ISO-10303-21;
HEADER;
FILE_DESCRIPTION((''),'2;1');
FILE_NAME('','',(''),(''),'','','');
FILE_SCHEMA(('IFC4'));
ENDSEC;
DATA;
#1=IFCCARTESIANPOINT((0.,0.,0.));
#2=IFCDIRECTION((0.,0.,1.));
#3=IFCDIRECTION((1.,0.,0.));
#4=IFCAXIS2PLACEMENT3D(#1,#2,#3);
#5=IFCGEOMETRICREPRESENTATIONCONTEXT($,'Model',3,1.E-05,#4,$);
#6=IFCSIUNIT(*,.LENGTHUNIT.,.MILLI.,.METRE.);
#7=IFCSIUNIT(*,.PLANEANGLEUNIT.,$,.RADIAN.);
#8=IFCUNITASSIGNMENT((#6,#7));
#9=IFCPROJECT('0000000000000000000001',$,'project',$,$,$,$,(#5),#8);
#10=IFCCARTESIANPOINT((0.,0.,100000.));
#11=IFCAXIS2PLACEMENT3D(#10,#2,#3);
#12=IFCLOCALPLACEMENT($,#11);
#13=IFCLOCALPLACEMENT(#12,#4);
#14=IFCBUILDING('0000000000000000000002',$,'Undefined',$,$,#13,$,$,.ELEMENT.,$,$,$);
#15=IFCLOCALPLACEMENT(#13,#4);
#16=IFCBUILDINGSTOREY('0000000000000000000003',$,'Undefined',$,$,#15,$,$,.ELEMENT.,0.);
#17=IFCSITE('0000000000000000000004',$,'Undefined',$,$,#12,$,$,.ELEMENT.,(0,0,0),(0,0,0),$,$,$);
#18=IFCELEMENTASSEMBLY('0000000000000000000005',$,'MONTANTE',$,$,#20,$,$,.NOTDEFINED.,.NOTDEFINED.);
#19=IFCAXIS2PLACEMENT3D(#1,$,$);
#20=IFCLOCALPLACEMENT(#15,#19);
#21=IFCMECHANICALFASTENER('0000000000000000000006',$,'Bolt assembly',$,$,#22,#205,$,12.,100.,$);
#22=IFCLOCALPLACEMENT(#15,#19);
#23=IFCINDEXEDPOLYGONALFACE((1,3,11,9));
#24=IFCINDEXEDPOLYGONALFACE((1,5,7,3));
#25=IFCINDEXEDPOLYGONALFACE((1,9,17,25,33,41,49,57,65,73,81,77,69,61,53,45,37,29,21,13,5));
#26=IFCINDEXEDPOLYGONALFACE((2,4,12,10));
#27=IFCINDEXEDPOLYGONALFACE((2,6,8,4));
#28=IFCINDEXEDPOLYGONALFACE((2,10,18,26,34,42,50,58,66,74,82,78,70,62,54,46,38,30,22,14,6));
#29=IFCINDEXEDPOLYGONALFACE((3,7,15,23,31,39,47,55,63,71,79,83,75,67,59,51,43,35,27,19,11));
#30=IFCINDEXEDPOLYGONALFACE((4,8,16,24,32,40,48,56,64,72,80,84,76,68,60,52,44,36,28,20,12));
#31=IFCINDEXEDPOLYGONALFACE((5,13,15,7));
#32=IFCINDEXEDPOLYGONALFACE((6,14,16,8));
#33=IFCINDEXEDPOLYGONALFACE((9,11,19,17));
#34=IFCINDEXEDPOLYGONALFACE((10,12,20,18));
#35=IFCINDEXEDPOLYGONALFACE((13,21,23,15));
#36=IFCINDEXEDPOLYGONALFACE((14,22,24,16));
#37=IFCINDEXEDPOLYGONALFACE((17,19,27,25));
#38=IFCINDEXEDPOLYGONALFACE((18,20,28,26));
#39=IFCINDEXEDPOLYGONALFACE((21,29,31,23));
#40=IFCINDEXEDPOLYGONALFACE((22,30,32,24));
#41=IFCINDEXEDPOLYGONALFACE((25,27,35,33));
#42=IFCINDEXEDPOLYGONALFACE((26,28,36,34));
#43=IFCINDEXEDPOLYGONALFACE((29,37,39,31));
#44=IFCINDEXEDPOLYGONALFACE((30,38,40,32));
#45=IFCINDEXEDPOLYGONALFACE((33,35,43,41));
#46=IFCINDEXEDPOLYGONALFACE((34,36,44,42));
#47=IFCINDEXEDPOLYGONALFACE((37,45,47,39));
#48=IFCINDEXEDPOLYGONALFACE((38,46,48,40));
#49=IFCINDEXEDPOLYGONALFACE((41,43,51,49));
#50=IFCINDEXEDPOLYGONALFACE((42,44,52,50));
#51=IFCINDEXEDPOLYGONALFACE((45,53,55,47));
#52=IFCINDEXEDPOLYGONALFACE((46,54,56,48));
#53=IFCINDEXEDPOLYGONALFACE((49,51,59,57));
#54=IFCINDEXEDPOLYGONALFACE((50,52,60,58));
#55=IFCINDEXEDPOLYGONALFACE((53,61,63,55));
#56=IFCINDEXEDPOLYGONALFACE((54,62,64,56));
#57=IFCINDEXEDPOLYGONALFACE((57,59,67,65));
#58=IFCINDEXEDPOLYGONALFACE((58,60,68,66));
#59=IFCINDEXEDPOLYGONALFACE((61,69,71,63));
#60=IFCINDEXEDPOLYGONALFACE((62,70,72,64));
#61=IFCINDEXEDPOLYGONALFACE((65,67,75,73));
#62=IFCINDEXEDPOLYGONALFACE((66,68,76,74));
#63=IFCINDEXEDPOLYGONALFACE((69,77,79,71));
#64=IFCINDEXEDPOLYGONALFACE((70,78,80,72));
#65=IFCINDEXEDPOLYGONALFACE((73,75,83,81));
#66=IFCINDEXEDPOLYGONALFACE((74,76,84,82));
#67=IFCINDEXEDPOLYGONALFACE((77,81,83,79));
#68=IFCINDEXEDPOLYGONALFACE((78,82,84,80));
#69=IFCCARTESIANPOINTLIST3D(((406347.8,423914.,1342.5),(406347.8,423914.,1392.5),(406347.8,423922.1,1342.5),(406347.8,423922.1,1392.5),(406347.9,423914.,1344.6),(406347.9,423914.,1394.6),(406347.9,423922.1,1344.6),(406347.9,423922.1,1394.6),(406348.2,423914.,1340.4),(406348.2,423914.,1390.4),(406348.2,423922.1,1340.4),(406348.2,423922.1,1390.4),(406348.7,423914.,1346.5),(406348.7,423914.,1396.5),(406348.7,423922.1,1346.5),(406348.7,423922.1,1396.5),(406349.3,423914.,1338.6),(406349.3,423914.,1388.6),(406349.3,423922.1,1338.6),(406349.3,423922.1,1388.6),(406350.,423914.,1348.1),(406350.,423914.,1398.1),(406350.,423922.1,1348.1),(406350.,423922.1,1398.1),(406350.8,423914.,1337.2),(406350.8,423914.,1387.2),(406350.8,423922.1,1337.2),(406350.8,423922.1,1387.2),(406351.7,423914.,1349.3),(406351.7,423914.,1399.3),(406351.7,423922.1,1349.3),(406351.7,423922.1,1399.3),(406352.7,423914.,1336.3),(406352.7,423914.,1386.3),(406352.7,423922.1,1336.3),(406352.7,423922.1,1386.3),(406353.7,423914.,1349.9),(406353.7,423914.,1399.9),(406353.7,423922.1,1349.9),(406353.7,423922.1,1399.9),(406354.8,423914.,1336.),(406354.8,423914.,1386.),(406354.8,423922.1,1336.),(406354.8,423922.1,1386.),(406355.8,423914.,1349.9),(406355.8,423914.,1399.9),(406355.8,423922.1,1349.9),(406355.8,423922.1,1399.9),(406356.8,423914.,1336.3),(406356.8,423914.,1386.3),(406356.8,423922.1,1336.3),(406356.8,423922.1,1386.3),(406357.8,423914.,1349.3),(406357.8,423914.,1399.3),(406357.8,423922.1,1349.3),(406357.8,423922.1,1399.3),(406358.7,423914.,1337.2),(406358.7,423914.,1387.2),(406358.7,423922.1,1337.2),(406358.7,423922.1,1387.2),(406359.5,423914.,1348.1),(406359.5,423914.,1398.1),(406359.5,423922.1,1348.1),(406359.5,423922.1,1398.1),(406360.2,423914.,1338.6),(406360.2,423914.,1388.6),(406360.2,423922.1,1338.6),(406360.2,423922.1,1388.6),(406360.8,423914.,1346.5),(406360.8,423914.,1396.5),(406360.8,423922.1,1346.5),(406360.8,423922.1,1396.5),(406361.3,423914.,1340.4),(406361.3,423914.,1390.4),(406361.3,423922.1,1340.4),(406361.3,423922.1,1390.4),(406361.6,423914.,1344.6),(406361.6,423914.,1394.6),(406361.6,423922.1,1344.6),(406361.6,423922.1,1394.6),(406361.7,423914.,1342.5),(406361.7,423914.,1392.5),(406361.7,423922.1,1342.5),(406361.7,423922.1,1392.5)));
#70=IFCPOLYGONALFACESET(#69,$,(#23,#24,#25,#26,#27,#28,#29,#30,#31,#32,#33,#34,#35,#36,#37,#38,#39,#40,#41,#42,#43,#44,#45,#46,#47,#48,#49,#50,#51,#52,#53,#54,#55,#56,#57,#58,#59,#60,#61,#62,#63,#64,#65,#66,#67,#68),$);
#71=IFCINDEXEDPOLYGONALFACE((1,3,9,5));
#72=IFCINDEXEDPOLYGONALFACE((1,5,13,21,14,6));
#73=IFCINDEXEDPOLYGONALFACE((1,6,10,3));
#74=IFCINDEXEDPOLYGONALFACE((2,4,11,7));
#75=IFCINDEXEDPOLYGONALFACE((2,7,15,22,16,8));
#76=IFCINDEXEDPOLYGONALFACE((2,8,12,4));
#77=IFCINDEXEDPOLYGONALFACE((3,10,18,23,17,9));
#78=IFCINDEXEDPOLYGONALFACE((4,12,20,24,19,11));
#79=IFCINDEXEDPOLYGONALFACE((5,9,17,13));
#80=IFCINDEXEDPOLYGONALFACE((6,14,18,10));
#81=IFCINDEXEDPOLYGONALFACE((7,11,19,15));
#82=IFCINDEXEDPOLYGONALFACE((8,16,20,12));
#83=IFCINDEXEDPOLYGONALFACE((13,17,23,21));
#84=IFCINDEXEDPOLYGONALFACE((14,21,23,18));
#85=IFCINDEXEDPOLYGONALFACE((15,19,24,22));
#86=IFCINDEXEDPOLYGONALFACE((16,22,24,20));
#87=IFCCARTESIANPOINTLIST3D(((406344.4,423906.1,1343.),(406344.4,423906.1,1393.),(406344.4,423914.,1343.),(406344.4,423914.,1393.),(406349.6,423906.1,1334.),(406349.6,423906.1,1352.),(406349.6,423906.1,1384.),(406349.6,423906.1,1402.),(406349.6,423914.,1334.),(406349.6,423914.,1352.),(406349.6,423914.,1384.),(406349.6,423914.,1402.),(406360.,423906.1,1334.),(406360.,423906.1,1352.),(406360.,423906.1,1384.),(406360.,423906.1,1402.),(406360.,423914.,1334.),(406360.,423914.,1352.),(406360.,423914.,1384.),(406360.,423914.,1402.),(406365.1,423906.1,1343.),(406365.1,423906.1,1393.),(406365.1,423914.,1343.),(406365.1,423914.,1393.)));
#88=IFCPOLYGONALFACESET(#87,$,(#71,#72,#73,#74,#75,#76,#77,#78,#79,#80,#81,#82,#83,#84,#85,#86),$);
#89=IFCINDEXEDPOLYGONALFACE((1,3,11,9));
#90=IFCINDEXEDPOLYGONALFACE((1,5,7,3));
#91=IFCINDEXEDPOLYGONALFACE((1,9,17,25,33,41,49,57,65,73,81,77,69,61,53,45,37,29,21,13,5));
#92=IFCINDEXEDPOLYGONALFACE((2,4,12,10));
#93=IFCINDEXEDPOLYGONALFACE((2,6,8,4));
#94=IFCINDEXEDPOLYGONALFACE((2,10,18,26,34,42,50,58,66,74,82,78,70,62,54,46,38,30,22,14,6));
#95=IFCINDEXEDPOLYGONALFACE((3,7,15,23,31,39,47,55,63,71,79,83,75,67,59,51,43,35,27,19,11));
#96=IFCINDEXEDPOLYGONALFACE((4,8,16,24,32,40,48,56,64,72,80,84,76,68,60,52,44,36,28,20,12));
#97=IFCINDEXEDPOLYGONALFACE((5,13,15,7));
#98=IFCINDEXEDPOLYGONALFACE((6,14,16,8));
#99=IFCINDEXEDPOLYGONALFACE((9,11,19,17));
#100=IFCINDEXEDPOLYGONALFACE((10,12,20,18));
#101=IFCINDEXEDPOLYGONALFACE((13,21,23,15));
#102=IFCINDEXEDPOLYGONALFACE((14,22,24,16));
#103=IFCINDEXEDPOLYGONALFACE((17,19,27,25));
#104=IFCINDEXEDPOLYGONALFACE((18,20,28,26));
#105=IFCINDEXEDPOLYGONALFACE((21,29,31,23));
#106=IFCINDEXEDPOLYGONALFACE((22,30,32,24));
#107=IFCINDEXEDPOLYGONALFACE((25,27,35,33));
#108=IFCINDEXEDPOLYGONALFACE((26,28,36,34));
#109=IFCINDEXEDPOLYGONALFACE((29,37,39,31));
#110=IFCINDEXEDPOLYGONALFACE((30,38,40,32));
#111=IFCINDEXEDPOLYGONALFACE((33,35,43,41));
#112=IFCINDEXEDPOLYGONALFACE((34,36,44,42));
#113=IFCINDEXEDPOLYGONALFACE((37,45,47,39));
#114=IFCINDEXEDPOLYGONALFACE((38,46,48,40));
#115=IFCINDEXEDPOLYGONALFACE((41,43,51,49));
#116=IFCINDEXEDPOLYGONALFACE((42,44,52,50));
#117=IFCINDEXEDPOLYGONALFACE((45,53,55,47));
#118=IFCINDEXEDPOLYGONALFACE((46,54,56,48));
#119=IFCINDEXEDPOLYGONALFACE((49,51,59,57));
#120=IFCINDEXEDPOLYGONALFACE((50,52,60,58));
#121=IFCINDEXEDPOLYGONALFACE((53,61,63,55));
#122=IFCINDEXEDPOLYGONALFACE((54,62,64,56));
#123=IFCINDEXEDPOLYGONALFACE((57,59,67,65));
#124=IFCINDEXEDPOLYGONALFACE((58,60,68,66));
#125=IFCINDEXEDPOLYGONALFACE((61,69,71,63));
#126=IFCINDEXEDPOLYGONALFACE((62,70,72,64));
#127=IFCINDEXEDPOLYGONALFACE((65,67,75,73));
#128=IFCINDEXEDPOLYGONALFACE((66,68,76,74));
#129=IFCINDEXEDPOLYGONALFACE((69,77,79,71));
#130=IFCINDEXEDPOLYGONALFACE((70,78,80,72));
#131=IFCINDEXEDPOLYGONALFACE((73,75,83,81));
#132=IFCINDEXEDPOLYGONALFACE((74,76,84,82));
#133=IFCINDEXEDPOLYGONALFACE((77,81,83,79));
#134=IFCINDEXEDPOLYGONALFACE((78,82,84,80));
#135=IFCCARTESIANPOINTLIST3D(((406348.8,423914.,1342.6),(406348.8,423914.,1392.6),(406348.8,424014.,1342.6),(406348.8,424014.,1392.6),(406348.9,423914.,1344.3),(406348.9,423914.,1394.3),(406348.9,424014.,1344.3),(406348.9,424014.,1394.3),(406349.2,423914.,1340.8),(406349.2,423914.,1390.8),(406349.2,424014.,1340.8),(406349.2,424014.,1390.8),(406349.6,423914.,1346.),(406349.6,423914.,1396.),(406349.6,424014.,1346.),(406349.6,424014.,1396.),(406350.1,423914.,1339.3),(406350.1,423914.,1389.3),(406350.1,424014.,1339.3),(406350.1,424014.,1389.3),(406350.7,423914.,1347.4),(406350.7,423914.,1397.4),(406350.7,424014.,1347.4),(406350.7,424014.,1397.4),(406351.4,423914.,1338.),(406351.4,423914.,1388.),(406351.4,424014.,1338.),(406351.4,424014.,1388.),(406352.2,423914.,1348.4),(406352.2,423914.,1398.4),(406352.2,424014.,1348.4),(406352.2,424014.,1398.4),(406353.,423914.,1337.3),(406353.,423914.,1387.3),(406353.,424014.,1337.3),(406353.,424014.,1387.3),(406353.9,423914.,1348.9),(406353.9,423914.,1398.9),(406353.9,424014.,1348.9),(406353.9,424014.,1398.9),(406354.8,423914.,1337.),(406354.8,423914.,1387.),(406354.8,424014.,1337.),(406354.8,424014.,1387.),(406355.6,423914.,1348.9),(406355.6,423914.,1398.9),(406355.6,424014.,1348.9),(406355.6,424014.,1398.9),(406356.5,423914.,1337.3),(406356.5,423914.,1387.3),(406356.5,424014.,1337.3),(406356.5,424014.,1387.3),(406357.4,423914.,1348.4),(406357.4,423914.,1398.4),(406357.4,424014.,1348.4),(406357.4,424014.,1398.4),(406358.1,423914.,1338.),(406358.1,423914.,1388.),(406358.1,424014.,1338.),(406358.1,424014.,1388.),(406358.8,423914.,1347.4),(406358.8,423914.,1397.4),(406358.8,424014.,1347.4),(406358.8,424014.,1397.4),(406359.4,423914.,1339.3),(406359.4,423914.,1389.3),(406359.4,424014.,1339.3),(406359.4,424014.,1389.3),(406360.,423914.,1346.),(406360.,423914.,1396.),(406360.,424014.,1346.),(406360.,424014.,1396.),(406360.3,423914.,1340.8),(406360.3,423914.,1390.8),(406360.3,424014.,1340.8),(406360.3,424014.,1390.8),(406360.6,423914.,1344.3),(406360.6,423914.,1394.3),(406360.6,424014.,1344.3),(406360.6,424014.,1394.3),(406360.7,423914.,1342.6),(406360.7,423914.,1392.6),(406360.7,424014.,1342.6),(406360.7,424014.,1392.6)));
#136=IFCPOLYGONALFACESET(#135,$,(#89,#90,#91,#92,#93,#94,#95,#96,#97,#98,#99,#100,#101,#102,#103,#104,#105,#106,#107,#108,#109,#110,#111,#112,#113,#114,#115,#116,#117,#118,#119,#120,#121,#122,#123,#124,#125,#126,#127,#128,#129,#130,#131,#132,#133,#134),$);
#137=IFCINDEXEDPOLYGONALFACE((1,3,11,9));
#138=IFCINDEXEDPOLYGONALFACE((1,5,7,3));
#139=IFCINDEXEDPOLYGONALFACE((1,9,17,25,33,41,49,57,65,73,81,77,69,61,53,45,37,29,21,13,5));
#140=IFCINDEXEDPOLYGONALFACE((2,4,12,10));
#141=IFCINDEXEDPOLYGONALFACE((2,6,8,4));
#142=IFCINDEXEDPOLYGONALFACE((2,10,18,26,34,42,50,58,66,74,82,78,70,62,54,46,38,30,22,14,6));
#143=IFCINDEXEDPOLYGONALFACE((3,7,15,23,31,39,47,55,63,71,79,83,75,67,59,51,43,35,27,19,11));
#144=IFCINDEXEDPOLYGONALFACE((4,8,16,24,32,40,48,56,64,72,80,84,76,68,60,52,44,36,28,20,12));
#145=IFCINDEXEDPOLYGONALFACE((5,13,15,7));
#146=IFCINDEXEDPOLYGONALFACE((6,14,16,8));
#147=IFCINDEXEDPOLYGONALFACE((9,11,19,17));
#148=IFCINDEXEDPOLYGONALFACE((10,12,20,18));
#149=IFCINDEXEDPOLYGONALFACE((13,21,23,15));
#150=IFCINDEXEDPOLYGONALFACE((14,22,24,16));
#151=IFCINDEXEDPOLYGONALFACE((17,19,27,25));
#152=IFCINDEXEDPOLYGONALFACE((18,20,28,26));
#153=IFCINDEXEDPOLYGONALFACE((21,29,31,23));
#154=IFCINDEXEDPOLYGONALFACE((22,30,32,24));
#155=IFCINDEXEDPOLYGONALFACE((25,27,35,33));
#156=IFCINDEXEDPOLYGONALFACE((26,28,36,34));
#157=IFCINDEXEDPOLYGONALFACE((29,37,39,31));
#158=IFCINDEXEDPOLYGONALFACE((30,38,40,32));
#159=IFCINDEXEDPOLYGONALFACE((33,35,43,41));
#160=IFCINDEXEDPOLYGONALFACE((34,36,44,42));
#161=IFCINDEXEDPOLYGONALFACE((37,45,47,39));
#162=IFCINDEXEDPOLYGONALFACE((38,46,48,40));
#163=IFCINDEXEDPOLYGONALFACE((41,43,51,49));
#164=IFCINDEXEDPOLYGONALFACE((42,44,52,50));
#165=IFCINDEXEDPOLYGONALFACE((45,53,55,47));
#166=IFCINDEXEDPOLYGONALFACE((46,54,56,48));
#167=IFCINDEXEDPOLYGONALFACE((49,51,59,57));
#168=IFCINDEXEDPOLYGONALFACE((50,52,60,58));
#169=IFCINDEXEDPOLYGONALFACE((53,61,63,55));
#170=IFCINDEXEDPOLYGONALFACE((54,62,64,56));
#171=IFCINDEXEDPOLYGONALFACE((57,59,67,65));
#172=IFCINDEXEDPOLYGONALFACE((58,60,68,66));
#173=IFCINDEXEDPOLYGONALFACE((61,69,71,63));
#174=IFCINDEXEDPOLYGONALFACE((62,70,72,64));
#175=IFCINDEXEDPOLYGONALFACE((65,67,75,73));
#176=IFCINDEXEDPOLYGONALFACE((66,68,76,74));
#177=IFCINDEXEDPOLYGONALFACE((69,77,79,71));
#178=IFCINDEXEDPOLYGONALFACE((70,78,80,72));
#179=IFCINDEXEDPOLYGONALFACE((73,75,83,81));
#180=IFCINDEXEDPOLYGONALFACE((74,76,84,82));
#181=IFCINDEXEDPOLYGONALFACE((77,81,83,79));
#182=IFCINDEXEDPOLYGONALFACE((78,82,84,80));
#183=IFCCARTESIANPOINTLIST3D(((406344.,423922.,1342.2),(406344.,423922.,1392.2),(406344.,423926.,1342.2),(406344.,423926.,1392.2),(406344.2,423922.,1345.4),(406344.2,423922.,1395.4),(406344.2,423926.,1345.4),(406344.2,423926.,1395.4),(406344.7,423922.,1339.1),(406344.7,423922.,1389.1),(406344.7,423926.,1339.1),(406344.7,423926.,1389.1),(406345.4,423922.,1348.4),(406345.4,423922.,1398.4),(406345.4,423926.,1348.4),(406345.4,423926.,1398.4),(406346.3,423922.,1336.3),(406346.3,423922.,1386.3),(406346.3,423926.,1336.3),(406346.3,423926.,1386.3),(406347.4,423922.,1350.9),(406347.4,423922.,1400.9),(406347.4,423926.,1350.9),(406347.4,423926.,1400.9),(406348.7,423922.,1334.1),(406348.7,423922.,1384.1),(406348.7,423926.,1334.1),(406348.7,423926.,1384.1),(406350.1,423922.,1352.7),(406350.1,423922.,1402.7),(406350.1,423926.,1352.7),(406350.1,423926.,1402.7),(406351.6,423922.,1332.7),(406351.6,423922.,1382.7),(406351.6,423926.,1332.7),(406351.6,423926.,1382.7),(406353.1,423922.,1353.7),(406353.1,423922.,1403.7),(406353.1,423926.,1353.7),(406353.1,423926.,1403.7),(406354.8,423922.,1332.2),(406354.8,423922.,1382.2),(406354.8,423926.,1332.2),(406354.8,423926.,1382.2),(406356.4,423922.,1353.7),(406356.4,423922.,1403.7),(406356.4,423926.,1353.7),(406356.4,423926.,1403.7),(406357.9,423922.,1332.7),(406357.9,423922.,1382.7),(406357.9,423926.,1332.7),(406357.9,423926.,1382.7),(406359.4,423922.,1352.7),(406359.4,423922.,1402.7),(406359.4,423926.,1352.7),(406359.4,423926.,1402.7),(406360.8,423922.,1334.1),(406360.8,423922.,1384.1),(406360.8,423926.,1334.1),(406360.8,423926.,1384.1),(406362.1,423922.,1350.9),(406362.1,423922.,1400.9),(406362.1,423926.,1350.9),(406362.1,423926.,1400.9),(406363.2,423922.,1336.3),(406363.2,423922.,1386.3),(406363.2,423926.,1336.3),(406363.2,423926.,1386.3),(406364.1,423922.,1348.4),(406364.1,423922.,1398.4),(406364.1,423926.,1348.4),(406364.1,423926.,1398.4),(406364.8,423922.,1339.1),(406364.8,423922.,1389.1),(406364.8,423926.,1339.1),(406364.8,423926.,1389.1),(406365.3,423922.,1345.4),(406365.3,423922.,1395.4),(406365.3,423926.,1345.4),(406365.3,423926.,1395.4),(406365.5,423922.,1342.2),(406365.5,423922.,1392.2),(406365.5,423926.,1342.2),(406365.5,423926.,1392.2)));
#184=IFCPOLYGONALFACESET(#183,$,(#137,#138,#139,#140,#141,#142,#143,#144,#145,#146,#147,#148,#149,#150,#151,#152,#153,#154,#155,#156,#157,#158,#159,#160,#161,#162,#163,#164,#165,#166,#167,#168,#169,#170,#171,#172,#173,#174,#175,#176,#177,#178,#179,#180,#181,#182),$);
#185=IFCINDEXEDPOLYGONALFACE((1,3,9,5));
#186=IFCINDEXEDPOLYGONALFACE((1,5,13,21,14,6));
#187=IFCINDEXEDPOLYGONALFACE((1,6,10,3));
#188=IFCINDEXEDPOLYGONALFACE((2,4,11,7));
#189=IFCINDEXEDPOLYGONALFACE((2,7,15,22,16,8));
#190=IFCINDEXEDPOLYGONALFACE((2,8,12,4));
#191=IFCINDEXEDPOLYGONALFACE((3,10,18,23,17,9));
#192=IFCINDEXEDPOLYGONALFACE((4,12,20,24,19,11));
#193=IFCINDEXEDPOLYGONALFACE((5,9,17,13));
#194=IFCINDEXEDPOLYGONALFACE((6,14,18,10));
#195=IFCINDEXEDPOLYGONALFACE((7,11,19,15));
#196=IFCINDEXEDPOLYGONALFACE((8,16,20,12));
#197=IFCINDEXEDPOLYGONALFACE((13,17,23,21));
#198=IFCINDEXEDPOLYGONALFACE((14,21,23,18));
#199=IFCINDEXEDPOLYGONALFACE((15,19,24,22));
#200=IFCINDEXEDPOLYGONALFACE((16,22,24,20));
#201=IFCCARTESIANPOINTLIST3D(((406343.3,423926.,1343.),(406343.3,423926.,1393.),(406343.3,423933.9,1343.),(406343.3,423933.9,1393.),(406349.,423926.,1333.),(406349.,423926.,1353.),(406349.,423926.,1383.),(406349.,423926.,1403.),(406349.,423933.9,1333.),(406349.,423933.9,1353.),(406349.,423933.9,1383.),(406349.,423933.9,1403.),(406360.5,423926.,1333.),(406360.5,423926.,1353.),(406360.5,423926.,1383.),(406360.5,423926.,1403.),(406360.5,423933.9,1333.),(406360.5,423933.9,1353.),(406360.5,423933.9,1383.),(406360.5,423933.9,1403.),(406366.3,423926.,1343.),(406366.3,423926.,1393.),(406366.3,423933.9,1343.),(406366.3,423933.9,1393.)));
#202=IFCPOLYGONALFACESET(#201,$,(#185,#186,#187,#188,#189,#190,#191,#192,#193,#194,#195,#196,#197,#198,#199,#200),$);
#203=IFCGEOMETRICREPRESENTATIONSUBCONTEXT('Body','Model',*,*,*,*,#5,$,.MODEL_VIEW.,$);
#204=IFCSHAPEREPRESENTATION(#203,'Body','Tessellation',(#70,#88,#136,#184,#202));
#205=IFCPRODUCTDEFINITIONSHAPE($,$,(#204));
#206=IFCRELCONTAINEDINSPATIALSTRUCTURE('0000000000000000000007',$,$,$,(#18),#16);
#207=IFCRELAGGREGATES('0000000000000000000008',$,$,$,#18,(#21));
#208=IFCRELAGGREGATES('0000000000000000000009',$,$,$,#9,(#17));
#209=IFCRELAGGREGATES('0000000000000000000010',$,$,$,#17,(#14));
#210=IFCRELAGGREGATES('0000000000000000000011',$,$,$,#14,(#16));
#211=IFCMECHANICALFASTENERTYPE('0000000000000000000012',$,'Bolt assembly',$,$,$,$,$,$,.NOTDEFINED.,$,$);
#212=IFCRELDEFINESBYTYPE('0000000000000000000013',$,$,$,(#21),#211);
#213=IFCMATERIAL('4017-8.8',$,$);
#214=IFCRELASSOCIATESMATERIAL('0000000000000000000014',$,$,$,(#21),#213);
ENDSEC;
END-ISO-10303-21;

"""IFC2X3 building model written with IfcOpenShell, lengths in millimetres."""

from ifc_helpers import new_model, si_unit, frame, origin_with_axes, origin_2d_with_axis, place, context, subcontext, project, spatial, polyline, circle, outline, extrude, source, transform, mapped, material, type_object, element, aggregate, save


model = new_model("IFC2X3")

# Units and contexts
model_context = context("Model", 3, precision=1e-05, world=origin_with_axes())
body_context = subcontext(model_context, "Body", "Model", "MODEL_VIEW")
ifc_project = project(units=[si_unit("LENGTHUNIT", "METRE", prefix="MILLI"), si_unit("PLANEANGLEUNIT", "RADIAN")], contexts=[model_context])

# Site, building, storey
site_placement = place(None, frame((0.0, 0.0, 100000.0), z_axis=(0.0, 0.0, 1.0), x_axis=(1.0, 0.0, 0.0)))
site = spatial("IfcSite", under=ifc_project, at=site_placement, Name="Undefined", CompositionType="ELEMENT", RefLatitude=(0, 0, 0), RefLongitude=(0, 0, 0))
building_placement = place(site_placement, origin_with_axes())
building = spatial("IfcBuilding", under=site, at=building_placement, Name="Undefined", CompositionType="ELEMENT")
storey_placement = place(building_placement, origin_with_axes())
storey = spatial("IfcBuildingStorey", under=building, at=storey_placement, Name="Undefined", CompositionType="ELEMENT", Elevation=0.0)

# Element assembly
assembly_1_placement = place(storey_placement, origin_with_axes())
assembly_1 = element("IfcElementAssembly", 1, at=assembly_1_placement, inside=storey, Name="MONTANTE", AssemblyPlace="NOTDEFINED", PredefinedType="NOTDEFINED")

# Shared definitions
ifc_material_1 = material(Name="4017-8.8")
mechanical_fastener_type = type_object("IfcMechanicalFastenerType", Name="Bolt assembly")

# Mechanical fastener
shared_shape_1 = source(origin_with_axes(), body_context, "Body", "SweptSolid", [
    extrude(circle(Radius=7.0, at=origin_2d_with_axis()), frame((0.0, -8.0, 0.0), z_axis=(0.0, 1.0, 0.0), x_axis=(1.0, 0.0, 0.0)), (0.0, 0.0, 1.0), 8.1),
    extrude(outline(polyline([(9.0, -5.2), (9.0, 5.2), (0.0, 10.4), (-9.0, 5.2), (-9.0, -5.2), (0.0, -10.4), (9.0, -5.2)])), frame((0.0, -15.9, 0.0), z_axis=(0.0, 1.0, 0.0), x_axis=(1.0, 0.0, 0.0)), (0.0, 0.0, 1.0), 7.9),
    extrude(circle(Radius=6.0, at=origin_2d_with_axis()), frame((0.0, -8.0, 0.0), z_axis=(0.0, 1.0, 0.0), x_axis=(1.0, 0.0, 0.0)), (0.0, 0.0, 1.0), 100.0),
    extrude(circle(Radius=10.8, at=origin_2d_with_axis()), frame((0.0, 0.0, 0.0), z_axis=(0.0, 1.0, 0.0), x_axis=(1.0, 0.0, 0.0)), (0.0, 0.0, 1.0), 4.0),
    extrude(outline(polyline([(10.0, -5.8), (10.0, 5.8), (0.0, 11.5), (-10.0, 5.8), (-10.0, -5.8), (0.0, -11.5), (10.0, -5.8)])), frame((0.0, 4.0, 0.0), z_axis=(0.0, 1.0, 0.0), x_axis=(1.0, 0.0, 0.0)), (0.0, 0.0, 1.0), 7.9),
])
mechanical_fastener_1_placement = place(assembly_1_placement, frame((406354.8, 423922.0, 1393.0), z_axis=(1.0, 0.0, 0.0), x_axis=(0.0, 0.0, -1.0)))
mechanical_fastener_1 = element("IfcMechanicalFastener", 2, at=mechanical_fastener_1_placement, type_object=mechanical_fastener_type, material=ifc_material_1, Name="Bolt assembly", NominalDiameter=12.0, NominalLength=100.0, context=body_context, shape_type="MappedRepresentation", body=[
    mapped(shared_shape_1, transform((0.0, 0.0, 0.0))),
    mapped(shared_shape_1, transform((50.0, 0.0, 0.0))),
])
aggregate(assembly_1, [mechanical_fastener_1])

save(model, "model.ifc")
